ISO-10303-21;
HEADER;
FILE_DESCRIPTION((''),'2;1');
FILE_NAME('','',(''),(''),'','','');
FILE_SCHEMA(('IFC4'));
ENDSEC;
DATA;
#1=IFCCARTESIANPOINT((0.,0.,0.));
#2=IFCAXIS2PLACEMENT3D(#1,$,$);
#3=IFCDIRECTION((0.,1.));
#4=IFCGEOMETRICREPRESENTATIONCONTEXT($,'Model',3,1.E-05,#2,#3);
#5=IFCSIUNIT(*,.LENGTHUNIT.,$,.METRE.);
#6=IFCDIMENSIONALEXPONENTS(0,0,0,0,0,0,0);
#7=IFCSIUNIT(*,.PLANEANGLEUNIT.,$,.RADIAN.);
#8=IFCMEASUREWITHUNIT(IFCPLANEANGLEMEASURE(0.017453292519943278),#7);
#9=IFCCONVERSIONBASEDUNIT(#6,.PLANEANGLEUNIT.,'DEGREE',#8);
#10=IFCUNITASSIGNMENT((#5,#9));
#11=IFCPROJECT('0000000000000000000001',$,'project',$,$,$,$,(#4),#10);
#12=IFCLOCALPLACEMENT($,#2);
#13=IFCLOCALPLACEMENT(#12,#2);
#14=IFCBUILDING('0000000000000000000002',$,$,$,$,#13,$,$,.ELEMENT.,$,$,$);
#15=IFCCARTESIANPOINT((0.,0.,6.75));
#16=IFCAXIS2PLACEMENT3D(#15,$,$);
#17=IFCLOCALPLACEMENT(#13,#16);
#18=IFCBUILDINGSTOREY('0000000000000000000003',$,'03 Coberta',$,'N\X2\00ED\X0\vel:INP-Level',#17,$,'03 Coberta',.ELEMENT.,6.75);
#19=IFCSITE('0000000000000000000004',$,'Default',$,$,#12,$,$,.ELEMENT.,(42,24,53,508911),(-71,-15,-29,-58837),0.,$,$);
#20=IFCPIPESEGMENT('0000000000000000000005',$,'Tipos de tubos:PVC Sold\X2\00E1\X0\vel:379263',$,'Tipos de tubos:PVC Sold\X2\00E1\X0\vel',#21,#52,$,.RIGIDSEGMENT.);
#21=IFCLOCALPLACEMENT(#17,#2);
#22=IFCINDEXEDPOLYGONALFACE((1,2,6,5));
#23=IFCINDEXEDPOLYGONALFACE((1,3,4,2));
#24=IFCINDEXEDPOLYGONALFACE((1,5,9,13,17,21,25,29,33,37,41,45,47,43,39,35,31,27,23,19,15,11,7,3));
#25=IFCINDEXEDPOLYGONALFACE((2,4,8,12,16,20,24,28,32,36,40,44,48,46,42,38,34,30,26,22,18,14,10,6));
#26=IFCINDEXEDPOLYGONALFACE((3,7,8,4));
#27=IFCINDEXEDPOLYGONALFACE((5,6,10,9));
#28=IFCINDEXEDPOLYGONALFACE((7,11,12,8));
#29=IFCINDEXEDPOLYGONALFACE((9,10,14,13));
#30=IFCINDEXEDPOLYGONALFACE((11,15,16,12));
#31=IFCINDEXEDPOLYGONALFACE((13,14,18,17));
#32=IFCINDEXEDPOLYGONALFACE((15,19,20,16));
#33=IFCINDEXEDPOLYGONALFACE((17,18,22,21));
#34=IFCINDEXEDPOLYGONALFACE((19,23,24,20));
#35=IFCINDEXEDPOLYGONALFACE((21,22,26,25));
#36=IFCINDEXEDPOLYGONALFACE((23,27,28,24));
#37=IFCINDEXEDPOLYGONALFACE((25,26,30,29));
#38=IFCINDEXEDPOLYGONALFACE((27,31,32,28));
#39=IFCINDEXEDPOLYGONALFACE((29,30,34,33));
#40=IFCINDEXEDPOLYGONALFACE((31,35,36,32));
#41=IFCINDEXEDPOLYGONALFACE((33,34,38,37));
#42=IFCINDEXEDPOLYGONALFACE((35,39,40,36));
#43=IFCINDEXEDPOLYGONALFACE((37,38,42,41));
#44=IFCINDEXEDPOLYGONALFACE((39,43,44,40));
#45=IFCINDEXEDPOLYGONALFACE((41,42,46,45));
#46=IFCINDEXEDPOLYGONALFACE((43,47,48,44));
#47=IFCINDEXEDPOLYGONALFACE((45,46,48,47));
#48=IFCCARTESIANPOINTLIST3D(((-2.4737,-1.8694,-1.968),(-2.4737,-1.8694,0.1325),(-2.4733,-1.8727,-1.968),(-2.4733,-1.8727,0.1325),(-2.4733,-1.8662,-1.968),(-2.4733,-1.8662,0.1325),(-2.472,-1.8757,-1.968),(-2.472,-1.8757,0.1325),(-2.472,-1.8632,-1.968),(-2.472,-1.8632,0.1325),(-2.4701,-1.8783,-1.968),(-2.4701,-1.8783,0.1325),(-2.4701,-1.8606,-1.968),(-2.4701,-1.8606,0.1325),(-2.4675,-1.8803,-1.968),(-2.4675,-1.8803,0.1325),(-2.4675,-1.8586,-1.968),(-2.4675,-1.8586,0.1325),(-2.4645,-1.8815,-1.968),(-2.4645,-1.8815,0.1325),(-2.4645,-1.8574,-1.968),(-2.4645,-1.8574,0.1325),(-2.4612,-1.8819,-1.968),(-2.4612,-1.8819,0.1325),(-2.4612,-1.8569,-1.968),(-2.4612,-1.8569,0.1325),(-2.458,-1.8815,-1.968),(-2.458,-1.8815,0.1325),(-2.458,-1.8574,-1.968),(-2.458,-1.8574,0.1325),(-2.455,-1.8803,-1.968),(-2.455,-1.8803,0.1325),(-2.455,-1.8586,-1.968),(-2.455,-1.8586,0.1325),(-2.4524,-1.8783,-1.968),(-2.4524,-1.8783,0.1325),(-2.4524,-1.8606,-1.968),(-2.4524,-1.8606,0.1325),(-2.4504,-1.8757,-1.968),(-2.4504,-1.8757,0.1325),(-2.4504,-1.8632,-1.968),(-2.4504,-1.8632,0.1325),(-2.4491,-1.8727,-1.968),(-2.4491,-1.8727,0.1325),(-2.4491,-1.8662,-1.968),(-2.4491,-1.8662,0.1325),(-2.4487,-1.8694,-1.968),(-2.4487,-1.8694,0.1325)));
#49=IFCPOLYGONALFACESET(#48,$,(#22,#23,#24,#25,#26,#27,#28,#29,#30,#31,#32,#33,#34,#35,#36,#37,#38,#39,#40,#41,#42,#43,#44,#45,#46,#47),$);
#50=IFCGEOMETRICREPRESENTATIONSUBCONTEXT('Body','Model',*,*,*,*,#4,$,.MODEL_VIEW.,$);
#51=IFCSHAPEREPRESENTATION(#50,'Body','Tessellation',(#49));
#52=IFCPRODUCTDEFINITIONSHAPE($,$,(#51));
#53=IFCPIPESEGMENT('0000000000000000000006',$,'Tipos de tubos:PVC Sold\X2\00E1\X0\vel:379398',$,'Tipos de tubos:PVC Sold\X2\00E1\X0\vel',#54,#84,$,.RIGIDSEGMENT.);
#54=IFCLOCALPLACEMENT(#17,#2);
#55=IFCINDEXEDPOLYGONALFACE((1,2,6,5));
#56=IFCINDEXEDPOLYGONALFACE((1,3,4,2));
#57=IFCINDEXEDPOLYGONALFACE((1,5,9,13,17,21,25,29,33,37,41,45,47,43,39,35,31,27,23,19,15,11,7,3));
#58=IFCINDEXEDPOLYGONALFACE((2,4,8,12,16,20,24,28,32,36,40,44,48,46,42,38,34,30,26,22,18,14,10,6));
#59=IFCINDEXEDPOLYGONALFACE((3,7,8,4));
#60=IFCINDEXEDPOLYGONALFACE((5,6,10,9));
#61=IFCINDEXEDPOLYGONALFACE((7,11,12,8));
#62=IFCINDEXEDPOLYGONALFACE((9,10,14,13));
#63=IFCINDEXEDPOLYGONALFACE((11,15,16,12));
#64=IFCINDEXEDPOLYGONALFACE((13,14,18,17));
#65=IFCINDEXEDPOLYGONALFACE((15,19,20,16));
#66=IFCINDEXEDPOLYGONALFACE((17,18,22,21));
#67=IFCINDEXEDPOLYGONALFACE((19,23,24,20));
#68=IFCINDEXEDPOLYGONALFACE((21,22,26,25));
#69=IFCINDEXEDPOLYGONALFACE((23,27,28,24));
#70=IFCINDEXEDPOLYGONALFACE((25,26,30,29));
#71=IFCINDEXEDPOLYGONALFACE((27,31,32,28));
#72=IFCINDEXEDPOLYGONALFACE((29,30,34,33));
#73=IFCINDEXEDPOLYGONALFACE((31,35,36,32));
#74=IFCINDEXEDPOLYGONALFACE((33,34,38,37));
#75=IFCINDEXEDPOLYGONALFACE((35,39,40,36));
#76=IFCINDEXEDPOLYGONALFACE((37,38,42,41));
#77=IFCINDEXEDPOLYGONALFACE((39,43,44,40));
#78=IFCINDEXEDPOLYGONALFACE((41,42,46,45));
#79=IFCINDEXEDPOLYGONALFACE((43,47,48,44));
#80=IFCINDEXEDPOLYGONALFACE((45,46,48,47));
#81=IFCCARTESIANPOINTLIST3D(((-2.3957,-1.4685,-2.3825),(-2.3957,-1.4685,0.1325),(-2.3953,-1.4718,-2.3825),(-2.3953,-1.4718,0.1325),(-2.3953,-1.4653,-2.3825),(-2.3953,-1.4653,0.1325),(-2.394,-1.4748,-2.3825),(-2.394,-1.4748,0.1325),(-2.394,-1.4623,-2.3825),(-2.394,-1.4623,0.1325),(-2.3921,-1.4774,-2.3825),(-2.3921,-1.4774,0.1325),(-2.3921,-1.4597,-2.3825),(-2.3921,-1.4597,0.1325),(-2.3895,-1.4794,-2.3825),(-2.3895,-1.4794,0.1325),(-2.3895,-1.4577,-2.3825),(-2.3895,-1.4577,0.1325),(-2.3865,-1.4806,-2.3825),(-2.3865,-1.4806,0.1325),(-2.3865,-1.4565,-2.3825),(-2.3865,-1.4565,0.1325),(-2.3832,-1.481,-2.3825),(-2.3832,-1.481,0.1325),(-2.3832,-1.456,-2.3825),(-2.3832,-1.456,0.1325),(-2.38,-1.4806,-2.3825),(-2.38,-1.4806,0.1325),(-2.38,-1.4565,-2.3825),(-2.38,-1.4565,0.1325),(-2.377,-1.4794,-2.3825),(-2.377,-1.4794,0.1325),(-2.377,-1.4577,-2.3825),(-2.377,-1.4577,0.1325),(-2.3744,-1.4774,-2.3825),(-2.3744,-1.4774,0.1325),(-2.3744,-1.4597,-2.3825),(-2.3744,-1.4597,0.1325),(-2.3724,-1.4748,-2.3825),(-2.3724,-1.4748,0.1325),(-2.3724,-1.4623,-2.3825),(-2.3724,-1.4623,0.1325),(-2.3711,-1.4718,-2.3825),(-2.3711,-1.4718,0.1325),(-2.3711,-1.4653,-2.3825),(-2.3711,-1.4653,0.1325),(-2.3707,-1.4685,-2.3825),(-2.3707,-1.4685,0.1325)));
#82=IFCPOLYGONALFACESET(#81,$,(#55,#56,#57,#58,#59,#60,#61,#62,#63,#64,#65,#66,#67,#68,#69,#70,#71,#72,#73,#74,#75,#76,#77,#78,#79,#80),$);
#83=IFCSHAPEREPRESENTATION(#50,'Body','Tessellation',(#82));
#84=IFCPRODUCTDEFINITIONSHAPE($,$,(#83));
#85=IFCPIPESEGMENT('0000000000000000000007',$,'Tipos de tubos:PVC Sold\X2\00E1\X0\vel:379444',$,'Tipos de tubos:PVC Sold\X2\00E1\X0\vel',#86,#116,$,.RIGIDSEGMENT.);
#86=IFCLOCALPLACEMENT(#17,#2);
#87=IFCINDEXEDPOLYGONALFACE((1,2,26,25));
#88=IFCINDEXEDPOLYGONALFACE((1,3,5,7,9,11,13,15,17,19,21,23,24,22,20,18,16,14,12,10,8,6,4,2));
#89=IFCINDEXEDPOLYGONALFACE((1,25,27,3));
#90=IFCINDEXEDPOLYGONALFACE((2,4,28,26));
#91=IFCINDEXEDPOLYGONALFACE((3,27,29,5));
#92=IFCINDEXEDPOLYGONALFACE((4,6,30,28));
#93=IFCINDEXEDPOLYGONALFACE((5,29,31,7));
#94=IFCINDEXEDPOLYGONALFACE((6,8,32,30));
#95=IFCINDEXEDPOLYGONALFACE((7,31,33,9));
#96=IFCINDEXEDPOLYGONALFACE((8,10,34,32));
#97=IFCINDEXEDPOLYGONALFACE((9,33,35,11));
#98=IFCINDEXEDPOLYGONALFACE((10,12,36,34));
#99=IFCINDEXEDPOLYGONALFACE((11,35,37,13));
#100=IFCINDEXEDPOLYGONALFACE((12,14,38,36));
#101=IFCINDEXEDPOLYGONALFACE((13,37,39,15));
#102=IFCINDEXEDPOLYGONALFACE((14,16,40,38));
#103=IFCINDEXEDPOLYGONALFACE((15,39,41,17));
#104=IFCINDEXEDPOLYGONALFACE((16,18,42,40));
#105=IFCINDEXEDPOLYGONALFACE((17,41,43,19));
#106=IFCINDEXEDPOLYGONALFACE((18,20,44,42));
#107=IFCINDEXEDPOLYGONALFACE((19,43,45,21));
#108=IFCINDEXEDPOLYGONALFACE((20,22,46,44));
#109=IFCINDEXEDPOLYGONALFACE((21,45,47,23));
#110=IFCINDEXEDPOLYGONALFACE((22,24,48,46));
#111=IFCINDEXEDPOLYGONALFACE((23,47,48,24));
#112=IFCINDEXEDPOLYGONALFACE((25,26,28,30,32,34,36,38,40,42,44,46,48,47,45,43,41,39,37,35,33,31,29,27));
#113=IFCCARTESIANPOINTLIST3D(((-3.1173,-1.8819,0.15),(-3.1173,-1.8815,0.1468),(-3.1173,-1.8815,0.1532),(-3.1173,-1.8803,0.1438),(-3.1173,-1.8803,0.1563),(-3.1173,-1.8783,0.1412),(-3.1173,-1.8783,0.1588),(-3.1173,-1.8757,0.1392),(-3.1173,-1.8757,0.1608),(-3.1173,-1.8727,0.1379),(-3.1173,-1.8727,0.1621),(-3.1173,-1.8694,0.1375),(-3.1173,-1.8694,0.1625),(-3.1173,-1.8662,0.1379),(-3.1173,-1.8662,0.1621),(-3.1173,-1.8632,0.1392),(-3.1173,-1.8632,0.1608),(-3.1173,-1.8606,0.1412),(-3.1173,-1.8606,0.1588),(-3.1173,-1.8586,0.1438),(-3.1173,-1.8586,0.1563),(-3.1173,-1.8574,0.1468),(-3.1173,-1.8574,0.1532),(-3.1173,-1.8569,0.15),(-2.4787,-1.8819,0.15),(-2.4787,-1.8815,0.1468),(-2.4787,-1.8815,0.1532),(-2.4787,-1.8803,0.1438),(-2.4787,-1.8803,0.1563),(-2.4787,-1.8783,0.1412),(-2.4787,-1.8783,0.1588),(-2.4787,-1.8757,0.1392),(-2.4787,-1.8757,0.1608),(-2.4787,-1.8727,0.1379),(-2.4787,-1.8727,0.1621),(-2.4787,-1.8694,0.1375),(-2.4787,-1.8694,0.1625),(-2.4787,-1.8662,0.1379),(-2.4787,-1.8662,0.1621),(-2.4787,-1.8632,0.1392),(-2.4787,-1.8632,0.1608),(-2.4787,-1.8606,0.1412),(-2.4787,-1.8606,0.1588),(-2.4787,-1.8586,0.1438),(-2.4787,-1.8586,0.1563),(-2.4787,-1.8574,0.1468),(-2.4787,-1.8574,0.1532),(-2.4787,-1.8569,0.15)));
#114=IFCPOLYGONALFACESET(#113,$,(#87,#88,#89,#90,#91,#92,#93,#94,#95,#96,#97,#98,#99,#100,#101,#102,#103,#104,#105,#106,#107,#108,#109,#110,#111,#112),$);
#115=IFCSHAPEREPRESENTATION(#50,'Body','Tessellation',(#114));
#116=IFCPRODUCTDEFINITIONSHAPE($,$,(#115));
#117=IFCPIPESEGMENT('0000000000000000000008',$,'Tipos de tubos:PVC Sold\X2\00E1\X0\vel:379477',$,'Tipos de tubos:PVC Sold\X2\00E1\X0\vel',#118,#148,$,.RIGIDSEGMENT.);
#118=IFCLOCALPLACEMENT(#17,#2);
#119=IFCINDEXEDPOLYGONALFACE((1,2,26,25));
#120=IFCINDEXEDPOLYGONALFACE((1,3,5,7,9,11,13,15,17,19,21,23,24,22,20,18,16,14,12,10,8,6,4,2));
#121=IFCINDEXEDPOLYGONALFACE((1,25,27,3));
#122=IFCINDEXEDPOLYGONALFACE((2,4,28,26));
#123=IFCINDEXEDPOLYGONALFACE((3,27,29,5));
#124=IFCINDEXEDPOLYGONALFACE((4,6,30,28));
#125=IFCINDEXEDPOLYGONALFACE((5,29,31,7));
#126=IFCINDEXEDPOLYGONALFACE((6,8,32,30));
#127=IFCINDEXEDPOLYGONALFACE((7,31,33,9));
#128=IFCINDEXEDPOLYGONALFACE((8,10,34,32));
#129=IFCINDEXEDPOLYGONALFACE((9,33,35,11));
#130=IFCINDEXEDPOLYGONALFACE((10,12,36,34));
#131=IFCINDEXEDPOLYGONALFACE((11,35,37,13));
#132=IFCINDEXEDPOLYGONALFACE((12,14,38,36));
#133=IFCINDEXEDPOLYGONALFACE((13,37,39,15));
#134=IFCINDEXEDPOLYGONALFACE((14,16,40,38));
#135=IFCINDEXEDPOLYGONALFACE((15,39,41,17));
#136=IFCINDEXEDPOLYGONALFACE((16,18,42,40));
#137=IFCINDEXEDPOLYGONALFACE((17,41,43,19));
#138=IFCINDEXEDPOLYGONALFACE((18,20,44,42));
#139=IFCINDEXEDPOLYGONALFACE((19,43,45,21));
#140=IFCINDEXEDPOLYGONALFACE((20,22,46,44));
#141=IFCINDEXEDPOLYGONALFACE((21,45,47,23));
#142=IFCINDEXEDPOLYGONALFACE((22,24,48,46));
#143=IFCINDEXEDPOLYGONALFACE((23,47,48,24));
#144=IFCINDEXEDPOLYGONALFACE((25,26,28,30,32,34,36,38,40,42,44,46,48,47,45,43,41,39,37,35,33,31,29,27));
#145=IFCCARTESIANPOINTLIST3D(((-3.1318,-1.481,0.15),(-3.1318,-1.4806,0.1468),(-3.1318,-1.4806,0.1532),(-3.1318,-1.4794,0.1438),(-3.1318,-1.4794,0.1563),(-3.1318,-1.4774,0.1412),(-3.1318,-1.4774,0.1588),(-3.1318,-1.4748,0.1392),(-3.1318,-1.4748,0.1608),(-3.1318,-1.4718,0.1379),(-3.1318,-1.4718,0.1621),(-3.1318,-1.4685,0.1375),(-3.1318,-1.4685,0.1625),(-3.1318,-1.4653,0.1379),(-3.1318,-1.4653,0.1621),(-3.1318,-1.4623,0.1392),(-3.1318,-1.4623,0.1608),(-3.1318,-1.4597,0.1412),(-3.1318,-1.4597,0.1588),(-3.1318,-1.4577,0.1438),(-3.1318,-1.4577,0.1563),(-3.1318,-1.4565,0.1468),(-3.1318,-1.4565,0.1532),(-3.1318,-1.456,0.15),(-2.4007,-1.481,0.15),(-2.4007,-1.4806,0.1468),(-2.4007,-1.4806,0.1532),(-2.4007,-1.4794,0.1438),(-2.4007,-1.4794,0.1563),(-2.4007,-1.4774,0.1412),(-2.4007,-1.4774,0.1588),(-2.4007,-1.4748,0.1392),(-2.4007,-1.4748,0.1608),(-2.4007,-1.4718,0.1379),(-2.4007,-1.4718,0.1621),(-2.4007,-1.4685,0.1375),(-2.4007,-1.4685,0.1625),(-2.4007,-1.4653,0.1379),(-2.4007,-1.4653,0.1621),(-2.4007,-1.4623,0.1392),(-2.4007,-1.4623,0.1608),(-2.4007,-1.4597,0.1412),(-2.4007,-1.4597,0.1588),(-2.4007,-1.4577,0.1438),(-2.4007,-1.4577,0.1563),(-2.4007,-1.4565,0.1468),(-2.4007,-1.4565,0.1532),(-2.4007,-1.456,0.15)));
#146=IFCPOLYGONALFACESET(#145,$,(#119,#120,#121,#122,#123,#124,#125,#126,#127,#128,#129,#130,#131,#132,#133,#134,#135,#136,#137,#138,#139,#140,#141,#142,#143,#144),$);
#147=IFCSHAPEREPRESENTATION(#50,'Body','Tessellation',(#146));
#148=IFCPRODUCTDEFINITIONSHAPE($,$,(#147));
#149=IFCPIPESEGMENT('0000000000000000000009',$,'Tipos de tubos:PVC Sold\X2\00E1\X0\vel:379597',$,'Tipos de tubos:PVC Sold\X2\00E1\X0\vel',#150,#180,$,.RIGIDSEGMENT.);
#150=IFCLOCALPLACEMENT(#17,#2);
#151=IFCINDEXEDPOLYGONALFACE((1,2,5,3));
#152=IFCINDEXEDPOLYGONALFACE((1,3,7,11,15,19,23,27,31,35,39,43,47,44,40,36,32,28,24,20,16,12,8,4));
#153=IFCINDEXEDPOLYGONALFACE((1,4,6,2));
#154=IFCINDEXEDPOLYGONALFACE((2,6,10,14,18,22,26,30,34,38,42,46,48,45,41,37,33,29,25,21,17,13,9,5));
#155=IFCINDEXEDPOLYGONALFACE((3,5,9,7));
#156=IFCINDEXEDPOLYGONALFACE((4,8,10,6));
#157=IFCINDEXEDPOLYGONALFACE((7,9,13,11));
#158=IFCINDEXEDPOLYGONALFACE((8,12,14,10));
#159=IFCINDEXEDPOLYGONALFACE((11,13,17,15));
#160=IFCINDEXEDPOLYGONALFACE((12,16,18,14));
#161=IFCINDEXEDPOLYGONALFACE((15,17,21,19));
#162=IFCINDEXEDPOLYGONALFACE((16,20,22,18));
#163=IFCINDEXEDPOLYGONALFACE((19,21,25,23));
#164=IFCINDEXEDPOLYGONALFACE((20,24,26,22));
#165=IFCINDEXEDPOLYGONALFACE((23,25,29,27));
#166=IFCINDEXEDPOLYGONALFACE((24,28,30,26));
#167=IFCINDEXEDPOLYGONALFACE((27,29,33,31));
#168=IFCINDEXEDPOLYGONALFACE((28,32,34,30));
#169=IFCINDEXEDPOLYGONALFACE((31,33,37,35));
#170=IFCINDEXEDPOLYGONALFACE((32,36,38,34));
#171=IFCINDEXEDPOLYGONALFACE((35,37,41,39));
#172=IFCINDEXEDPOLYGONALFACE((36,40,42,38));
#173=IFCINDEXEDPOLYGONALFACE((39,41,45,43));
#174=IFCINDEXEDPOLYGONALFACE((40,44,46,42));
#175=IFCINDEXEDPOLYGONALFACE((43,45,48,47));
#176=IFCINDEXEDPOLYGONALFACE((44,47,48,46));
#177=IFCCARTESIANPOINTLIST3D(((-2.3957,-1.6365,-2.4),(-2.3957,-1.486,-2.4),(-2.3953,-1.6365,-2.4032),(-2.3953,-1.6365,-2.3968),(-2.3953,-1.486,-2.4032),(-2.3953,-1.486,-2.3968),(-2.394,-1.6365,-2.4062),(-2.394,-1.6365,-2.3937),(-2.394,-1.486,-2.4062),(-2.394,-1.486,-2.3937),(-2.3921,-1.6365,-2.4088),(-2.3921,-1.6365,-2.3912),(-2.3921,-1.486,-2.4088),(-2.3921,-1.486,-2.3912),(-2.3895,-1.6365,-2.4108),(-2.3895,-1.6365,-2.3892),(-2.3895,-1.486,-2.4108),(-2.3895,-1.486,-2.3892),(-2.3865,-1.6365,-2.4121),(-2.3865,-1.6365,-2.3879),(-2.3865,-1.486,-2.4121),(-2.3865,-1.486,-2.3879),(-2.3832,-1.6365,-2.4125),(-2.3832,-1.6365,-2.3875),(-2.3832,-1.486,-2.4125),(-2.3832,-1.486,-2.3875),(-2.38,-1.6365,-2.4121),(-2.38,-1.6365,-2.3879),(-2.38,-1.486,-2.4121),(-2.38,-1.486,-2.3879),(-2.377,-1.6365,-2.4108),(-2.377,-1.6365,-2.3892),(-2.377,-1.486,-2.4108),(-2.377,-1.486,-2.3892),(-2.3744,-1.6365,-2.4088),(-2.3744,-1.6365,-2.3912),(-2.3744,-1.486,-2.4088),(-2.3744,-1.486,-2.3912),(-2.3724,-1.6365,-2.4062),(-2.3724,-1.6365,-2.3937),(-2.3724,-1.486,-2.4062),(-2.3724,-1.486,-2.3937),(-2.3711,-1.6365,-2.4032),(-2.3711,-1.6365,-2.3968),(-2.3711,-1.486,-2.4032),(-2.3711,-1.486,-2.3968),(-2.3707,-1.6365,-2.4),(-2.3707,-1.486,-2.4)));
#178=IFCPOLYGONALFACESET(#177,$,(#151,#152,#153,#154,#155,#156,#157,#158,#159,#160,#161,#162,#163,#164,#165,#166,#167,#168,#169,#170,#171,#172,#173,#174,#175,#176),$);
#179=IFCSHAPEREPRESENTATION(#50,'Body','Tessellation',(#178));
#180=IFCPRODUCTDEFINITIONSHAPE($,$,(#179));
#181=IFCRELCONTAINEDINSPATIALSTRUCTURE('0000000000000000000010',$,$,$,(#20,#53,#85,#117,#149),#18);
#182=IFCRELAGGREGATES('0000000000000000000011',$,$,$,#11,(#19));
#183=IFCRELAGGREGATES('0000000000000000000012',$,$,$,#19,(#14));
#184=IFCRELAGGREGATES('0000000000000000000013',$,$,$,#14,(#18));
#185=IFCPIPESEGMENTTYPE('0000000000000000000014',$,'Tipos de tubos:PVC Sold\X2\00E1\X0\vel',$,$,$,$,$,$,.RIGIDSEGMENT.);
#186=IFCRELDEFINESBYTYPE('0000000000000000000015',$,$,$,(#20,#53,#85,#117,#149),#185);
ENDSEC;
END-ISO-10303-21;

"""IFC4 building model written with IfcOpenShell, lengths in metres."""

from ifc_helpers import new_model, entity, si_unit, converted_unit, direction, frame, origin, place, context, subcontext, project, spatial, arc, indexed_curve, outline, extrude, type_object, element, save


model = new_model("IFC4")

# Units and contexts
model_context = context("Model", 3, precision=1e-05, world=origin(), true_north=direction((0.0, 1.0)))
body_context = subcontext(model_context, "Body", "Model", "MODEL_VIEW")
ifc_project = project(units=[si_unit("LENGTHUNIT", "METRE"), converted_unit("PLANEANGLEUNIT", "DEGREE", entity("IfcPlaneAngleMeasure", 0.017453292519943278), si_unit("PLANEANGLEUNIT", "RADIAN"), dimensions=[0, 0, 0, 0, 0, 0, 0])], contexts=[model_context])

# Site, building, storey
site_placement = place(None, origin())
site = spatial("IfcSite", under=ifc_project, at=site_placement, Name="Default", CompositionType="ELEMENT", RefLatitude=(42, 24, 53, 508911), RefLongitude=(-71, -15, -29, -58837), RefElevation=0.0)
building_placement = place(site_placement, origin())
building = spatial("IfcBuilding", under=site, at=building_placement, CompositionType="ELEMENT")
storey_placement = place(building_placement, frame((0.0, 0.0, 6.75)))
storey = spatial("IfcBuildingStorey", under=building, at=storey_placement, Name="03 Coberta", ObjectType="Nível:INP-Level", LongName="03 Coberta", CompositionType="ELEMENT", Elevation=6.75)

# Pipe segments
pipe_segment_type = type_object("IfcPipeSegmentType", Name="Tipos de tubos:PVC Soldável", PredefinedType="RIGIDSEGMENT")
pipe_segment_1_placement = place(storey_placement, origin())
element("IfcPipeSegment", 1, at=pipe_segment_1_placement, inside=storey, type_object=pipe_segment_type, Name="Tipos de tubos:PVC Soldável:379263", ObjectType="Tipos de tubos:PVC Soldável", PredefinedType="RIGIDSEGMENT", context=body_context, shape_type="SweptSolid", body=[
    extrude(outline(indexed_curve([(0.0125, 0.0), (0.0088, 0.0088), (0.0, 0.0125), (-0.0088, 0.0088), (-0.0125, 0.0), (-0.0088, -0.0088), (0.0, -0.0125), (0.0088, -0.0088)], segments=[arc(1, 2, 3), arc(3, 4, 5), arc(5, 6, 7), arc(7, 8, 1)], self_intersect=False)), frame((-2.4612, -1.8694, -1.968)), (0.0, 0.0, 1.0), 2.1005),
])
pipe_segment_2_placement = place(storey_placement, origin())
element("IfcPipeSegment", 2, at=pipe_segment_2_placement, inside=storey, type_object=pipe_segment_type, Name="Tipos de tubos:PVC Soldável:379398", ObjectType="Tipos de tubos:PVC Soldável", PredefinedType="RIGIDSEGMENT", context=body_context, shape_type="SweptSolid", body=[
    extrude(outline(indexed_curve([(0.0125, 0.0), (0.0088, 0.0088), (0.0, 0.0125), (-0.0088, 0.0088), (-0.0125, 0.0), (-0.0088, -0.0088), (0.0, -0.0125), (0.0088, -0.0088)], segments=[arc(1, 2, 3), arc(3, 4, 5), arc(5, 6, 7), arc(7, 8, 1)], self_intersect=False)), frame((-2.3832, -1.4685, -2.3825), z_axis=(0.0, 0.0, 1.0), x_axis=(-1.0, 0.0, 0.0)), (0.0, 0.0, 1.0), 2.515),
])
pipe_segment_3_placement = place(storey_placement, origin())
element("IfcPipeSegment", 3, at=pipe_segment_3_placement, inside=storey, type_object=pipe_segment_type, Name="Tipos de tubos:PVC Soldável:379444", ObjectType="Tipos de tubos:PVC Soldável", PredefinedType="RIGIDSEGMENT", context=body_context, shape_type="SweptSolid", body=[
    extrude(outline(indexed_curve([(0.0125, 0.0), (0.0088, 0.0088), (0.0, 0.0125), (-0.0088, 0.0088), (-0.0125, 0.0), (-0.0088, -0.0088), (0.0, -0.0125), (0.0088, -0.0088)], segments=[arc(1, 2, 3), arc(3, 4, 5), arc(5, 6, 7), arc(7, 8, 1)], self_intersect=False)), frame((-3.1173, -1.8694, 0.15), z_axis=(1.0, 0.0, 0.0), x_axis=(0.0, -1.0, 0.0)), (0.0, 0.0, 1.0), 0.6386),
])
pipe_segment_4_placement = place(storey_placement, origin())
element("IfcPipeSegment", 4, at=pipe_segment_4_placement, inside=storey, type_object=pipe_segment_type, Name="Tipos de tubos:PVC Soldável:379477", ObjectType="Tipos de tubos:PVC Soldável", PredefinedType="RIGIDSEGMENT", context=body_context, shape_type="SweptSolid", body=[
    extrude(outline(indexed_curve([(0.0125, 0.0), (0.0088, 0.0088), (0.0, 0.0125), (-0.0088, 0.0088), (-0.0125, 0.0), (-0.0088, -0.0088), (0.0, -0.0125), (0.0088, -0.0088)], segments=[arc(1, 2, 3), arc(3, 4, 5), arc(5, 6, 7), arc(7, 8, 1)], self_intersect=False)), frame((-3.1318, -1.4685, 0.15), z_axis=(1.0, 0.0, 0.0), x_axis=(0.0, 1.0, 0.0)), (0.0, 0.0, 1.0), 0.7311),
])
pipe_segment_5_placement = place(storey_placement, origin())
element("IfcPipeSegment", 5, at=pipe_segment_5_placement, inside=storey, type_object=pipe_segment_type, Name="Tipos de tubos:PVC Soldável:379597", ObjectType="Tipos de tubos:PVC Soldável", PredefinedType="RIGIDSEGMENT", context=body_context, shape_type="SweptSolid", body=[
    extrude(outline(indexed_curve([(0.0125, 0.0), (0.0088, 0.0088), (0.0, 0.0125), (-0.0088, 0.0088), (-0.0125, 0.0), (-0.0088, -0.0088), (0.0, -0.0125), (0.0088, -0.0088)], segments=[arc(1, 2, 3), arc(3, 4, 5), arc(5, 6, 7), arc(7, 8, 1)], self_intersect=False)), frame((-2.3832, -1.6365, -2.4), z_axis=(0.0, 1.0, 0.0), x_axis=(-1.0, 0.0, 0.0)), (0.0, 0.0, 1.0), 0.1505),
])

save(model, "model.ifc")
